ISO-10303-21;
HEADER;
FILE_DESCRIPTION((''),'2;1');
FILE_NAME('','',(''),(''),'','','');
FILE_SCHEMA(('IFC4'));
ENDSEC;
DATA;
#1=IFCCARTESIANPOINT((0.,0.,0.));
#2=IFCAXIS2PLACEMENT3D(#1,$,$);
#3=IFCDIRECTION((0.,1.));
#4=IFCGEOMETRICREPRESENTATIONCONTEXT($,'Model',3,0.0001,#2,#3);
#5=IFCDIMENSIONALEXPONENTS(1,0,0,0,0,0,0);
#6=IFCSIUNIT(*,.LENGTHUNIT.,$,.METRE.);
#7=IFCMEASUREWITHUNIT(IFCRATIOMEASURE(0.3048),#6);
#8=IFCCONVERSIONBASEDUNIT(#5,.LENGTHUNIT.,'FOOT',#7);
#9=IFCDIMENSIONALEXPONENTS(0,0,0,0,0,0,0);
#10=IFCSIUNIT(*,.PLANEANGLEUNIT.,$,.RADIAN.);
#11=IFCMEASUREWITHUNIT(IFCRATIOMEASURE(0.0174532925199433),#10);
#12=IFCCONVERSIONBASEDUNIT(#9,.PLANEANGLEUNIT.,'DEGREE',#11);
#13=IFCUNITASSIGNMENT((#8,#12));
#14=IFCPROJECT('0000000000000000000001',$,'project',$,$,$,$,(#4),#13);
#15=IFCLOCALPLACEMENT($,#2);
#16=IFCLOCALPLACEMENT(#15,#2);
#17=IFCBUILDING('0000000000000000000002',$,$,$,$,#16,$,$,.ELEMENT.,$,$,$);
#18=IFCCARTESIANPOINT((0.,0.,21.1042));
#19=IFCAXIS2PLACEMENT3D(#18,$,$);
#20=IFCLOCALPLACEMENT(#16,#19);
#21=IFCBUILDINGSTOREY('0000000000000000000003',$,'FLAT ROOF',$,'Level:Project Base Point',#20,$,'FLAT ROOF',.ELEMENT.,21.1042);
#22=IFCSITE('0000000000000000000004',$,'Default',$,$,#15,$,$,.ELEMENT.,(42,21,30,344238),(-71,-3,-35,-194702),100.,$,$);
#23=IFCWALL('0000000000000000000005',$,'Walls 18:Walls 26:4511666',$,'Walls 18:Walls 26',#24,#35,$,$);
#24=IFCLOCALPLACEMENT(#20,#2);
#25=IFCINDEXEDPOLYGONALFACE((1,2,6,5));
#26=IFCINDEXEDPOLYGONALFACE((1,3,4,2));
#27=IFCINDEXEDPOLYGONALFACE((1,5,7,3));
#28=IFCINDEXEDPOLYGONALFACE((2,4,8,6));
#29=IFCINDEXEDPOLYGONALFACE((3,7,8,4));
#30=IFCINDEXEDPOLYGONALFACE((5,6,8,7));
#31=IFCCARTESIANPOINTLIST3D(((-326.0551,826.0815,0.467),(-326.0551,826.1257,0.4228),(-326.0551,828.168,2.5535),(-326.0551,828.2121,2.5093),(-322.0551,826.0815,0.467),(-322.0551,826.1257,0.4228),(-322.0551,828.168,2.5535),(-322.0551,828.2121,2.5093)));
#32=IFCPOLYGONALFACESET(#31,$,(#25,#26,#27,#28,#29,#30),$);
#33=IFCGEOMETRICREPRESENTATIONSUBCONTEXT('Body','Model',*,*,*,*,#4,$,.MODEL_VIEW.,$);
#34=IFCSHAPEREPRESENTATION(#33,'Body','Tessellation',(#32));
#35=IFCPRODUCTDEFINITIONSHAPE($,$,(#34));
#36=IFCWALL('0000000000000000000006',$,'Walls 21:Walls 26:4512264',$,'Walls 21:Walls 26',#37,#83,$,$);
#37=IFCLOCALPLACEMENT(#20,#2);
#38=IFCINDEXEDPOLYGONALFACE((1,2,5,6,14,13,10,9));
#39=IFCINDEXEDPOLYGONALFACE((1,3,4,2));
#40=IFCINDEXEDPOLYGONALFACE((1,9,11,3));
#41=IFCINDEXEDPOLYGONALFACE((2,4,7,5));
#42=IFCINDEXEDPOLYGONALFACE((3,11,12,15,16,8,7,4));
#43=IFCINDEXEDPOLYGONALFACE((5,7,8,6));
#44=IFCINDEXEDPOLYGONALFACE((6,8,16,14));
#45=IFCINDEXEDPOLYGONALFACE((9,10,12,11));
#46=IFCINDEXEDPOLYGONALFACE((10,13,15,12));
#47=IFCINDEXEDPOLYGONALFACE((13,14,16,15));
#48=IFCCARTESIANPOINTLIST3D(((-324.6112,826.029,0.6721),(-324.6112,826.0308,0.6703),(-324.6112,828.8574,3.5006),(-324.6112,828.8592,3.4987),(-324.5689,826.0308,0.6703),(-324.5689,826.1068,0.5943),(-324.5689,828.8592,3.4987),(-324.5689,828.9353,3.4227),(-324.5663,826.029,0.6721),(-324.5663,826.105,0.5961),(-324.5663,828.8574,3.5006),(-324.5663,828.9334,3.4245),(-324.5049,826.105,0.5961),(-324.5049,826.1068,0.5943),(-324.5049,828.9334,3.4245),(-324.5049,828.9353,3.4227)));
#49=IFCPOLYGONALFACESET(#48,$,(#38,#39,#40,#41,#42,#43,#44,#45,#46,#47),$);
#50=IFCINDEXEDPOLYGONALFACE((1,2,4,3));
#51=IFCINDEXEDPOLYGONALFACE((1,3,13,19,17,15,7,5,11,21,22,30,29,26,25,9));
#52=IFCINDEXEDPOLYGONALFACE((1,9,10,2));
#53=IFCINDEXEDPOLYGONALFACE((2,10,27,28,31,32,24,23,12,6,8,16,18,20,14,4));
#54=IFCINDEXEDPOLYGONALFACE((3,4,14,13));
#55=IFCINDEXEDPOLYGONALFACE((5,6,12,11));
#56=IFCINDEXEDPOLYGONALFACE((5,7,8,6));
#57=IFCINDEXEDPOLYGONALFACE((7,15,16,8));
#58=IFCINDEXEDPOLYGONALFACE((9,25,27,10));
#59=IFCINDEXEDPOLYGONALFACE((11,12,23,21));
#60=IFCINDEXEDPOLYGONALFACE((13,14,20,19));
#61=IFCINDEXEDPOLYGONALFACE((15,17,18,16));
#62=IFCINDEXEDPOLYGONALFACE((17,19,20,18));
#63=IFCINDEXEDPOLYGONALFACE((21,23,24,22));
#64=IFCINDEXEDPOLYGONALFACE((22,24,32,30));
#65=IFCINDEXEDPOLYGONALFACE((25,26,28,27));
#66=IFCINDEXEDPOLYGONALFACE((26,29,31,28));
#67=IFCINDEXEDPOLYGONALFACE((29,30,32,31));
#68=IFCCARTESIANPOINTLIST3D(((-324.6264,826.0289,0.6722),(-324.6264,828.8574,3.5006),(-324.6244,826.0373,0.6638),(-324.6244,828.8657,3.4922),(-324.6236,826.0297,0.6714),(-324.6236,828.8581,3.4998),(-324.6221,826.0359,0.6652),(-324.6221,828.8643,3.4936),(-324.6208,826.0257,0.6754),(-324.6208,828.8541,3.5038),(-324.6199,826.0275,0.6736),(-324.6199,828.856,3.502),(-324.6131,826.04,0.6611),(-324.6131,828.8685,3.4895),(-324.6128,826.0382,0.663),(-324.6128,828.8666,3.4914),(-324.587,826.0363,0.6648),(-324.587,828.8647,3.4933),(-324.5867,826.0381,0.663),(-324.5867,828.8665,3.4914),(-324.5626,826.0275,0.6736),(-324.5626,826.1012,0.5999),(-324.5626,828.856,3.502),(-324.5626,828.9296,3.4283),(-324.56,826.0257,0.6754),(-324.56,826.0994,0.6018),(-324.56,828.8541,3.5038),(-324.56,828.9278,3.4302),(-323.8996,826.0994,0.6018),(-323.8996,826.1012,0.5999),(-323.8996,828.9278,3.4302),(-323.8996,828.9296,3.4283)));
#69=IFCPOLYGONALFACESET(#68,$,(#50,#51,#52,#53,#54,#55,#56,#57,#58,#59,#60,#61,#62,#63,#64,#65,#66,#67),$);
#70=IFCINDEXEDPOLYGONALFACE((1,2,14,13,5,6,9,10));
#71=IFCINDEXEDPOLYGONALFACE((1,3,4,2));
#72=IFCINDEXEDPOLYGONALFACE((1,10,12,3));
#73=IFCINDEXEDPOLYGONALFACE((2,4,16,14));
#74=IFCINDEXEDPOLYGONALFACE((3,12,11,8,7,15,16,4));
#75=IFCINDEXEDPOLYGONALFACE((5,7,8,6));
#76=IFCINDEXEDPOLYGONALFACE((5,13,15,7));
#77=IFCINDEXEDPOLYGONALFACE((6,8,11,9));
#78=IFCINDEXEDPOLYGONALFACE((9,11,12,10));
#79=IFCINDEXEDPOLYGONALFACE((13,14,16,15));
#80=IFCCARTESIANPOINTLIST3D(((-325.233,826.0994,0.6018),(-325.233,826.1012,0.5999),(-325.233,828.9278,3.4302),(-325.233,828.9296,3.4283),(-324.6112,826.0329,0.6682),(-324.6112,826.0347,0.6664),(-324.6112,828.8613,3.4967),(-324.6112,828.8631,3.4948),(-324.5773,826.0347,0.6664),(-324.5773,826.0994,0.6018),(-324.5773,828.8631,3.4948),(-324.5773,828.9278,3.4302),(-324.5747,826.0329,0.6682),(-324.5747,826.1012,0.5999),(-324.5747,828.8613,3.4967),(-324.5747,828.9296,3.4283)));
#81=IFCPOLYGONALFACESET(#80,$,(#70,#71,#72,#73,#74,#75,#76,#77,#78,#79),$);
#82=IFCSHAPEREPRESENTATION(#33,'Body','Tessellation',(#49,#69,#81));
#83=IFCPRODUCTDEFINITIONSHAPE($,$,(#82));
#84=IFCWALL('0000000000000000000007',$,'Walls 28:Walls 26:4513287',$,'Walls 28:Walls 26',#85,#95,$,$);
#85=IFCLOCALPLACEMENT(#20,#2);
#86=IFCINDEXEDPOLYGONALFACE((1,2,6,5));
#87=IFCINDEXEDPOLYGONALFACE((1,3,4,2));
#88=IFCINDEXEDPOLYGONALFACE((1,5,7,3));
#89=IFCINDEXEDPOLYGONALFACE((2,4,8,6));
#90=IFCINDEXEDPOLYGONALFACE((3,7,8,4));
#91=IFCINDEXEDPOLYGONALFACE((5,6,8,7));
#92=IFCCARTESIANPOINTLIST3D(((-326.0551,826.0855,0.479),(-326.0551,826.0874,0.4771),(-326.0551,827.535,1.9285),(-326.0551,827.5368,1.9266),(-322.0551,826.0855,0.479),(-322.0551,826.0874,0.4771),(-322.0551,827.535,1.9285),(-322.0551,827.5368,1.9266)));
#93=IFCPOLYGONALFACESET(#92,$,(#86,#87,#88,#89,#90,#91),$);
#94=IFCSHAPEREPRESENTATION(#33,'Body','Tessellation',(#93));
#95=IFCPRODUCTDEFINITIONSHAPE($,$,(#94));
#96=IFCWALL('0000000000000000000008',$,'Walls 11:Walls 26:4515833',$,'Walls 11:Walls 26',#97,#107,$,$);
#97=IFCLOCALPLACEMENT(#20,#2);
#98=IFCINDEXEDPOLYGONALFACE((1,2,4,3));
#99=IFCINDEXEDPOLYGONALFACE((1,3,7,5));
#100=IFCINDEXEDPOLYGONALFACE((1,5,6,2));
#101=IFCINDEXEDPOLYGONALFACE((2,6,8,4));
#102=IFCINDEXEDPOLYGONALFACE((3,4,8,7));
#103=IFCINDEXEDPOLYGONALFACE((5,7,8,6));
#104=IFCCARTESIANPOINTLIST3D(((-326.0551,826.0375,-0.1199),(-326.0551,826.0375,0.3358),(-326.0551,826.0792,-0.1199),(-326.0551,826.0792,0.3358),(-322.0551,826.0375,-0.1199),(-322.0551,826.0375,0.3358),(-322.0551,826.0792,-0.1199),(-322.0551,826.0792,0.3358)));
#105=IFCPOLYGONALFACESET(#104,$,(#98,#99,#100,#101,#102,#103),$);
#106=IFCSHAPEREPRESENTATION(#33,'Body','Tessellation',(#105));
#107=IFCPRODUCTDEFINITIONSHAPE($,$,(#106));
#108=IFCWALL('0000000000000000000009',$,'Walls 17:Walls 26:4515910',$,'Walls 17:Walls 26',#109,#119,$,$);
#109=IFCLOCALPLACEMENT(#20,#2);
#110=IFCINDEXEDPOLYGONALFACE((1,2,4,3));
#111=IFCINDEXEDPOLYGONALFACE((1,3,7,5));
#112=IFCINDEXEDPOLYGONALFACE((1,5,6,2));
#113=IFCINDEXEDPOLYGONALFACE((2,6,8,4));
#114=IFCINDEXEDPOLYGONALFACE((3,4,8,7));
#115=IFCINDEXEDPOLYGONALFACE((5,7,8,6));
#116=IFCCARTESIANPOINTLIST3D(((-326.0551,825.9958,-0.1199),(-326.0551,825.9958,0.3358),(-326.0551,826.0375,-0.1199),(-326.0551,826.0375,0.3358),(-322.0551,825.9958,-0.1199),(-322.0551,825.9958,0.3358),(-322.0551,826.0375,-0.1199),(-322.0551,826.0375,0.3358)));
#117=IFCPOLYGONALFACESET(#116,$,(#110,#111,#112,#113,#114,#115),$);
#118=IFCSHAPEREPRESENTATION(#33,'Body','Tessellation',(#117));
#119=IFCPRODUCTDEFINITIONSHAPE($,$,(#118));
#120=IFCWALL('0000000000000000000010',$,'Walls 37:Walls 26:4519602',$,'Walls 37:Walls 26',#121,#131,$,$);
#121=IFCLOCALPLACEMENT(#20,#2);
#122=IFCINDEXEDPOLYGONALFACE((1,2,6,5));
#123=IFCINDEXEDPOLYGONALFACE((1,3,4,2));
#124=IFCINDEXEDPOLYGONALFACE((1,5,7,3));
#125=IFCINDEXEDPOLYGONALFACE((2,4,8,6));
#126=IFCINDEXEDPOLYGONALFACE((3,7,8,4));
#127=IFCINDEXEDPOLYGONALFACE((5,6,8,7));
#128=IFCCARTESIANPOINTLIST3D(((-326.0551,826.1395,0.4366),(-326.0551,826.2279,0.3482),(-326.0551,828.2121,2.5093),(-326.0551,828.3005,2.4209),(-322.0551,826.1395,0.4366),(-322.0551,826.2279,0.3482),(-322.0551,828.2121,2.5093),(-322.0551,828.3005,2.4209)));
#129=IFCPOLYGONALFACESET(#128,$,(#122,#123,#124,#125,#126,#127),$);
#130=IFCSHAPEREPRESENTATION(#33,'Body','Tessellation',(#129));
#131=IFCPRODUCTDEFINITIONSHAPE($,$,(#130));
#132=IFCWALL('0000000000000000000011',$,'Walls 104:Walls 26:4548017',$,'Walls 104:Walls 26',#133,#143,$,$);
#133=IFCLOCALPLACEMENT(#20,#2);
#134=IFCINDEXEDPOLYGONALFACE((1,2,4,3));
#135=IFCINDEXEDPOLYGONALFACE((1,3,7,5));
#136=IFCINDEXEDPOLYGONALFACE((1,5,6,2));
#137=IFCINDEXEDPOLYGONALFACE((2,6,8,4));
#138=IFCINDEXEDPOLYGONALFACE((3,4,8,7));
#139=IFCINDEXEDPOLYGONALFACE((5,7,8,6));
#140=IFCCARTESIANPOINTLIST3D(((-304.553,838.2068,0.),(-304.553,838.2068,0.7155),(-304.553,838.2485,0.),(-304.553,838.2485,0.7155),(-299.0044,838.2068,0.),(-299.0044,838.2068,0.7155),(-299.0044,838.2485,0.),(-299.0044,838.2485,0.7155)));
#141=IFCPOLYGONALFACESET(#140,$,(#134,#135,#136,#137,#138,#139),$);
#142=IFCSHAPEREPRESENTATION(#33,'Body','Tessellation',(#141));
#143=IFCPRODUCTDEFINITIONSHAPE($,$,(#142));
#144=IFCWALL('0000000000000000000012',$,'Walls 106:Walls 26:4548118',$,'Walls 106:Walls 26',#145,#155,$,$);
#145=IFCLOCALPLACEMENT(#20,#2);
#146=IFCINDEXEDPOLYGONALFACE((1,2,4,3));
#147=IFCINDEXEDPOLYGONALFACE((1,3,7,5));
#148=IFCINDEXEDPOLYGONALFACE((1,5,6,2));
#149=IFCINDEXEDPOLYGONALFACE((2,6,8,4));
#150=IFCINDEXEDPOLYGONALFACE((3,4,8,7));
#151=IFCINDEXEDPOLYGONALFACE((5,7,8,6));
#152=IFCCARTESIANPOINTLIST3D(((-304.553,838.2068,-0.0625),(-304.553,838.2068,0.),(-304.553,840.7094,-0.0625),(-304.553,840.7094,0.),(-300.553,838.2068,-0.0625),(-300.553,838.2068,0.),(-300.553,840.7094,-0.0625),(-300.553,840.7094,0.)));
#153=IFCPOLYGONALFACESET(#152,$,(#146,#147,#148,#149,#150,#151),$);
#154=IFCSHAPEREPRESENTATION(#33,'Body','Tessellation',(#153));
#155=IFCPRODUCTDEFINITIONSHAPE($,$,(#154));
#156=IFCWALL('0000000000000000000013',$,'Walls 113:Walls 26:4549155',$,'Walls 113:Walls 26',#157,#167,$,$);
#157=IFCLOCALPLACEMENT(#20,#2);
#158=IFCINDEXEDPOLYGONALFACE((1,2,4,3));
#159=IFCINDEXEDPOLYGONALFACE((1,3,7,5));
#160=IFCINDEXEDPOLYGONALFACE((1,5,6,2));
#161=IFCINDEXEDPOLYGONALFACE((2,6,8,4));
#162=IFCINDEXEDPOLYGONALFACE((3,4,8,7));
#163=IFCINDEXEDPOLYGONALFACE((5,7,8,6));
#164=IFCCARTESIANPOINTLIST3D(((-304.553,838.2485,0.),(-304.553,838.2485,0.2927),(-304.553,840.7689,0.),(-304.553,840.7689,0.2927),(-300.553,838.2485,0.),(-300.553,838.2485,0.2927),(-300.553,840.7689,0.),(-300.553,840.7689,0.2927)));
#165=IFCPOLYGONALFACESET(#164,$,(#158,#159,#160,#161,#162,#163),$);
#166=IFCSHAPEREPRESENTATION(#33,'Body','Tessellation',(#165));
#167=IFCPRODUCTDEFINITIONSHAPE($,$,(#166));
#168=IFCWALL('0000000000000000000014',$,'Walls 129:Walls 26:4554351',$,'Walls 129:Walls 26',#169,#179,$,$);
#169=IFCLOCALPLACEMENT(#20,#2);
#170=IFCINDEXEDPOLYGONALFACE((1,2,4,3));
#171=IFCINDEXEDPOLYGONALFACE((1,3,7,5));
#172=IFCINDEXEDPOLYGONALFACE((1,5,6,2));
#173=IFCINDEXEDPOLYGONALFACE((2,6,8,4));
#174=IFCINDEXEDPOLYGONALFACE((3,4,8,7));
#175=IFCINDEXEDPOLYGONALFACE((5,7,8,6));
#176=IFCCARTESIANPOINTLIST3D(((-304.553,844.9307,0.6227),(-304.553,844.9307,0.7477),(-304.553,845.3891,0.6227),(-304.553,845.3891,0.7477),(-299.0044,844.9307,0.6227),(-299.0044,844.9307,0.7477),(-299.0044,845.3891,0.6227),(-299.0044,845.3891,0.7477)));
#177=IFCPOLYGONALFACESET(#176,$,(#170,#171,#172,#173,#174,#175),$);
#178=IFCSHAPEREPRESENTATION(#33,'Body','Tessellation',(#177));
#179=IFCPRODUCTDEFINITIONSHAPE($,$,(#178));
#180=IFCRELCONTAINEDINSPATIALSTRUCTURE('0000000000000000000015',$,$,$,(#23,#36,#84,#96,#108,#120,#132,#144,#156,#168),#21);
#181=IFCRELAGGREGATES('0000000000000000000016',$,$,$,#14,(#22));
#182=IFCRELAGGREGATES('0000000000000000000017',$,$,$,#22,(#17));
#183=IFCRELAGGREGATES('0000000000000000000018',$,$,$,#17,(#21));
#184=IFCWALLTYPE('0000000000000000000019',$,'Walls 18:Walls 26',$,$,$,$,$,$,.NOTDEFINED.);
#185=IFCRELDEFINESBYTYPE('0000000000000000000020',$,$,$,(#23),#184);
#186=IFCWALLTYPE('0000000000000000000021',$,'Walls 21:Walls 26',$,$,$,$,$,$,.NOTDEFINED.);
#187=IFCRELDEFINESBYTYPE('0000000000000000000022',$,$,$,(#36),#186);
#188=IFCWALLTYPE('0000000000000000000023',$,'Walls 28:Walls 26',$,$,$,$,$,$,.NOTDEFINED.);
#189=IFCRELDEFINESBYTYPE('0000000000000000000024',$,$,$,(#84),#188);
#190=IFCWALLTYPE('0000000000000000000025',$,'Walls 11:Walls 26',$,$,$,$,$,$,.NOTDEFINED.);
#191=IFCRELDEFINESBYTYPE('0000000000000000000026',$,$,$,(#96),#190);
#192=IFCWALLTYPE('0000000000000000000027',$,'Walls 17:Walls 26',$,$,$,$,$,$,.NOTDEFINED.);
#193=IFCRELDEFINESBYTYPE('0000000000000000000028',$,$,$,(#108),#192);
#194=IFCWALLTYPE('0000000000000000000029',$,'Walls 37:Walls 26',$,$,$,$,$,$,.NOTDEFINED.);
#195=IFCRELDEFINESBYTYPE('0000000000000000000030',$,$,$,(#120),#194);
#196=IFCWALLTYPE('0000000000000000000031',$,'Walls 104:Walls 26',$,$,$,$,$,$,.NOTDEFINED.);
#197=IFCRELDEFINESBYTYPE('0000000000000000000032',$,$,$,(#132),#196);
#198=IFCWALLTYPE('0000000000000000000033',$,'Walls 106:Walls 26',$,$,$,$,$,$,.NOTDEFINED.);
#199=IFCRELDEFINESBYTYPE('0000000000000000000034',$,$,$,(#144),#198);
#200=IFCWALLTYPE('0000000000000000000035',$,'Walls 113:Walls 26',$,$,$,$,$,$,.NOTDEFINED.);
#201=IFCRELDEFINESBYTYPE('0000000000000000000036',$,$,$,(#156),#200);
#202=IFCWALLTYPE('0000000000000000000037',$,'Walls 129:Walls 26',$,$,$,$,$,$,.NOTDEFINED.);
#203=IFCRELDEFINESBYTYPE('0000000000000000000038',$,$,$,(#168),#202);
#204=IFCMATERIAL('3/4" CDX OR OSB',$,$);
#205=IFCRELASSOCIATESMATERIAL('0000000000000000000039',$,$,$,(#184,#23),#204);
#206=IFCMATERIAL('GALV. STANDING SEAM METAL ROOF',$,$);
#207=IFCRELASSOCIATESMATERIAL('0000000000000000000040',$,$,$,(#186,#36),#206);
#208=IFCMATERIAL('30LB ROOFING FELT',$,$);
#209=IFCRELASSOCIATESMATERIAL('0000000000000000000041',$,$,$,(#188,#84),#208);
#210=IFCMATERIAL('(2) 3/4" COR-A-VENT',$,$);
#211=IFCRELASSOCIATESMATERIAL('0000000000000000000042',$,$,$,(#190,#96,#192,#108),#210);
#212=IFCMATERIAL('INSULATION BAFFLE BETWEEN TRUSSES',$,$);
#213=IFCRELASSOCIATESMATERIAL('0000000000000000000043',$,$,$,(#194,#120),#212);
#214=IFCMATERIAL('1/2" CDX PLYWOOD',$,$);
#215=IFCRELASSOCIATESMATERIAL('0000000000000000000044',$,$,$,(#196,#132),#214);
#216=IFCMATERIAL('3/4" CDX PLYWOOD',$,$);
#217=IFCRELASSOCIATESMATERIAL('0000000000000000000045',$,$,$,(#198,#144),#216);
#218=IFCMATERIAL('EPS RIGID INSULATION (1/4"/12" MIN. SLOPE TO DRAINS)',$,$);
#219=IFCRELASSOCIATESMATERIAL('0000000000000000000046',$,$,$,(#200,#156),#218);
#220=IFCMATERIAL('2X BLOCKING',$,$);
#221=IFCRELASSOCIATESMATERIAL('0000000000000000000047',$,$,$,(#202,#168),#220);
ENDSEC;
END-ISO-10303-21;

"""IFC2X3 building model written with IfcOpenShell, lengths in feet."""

from ifc_helpers import new_model, entity, si_unit, converted_unit, direction, frame, frame_2d, origin, origin_2d_with_axis, place, context, subcontext, project, spatial, polyline, rectangle, outline, extrude, material, type_object, element, save


model = new_model("IFC2X3")

# Units and contexts
model_context = context("Model", 3, precision=0.0001, world=origin(), true_north=direction((0.0, 1.0)))
body_context = subcontext(model_context, "Body", "Model", "MODEL_VIEW")
ifc_project = project(units=[converted_unit("LENGTHUNIT", "FOOT", entity("IfcRatioMeasure", 0.3048), si_unit("LENGTHUNIT", "METRE"), dimensions=[1, 0, 0, 0, 0, 0, 0]), converted_unit("PLANEANGLEUNIT", "DEGREE", entity("IfcRatioMeasure", 0.0174532925199433), si_unit("PLANEANGLEUNIT", "RADIAN"), dimensions=[0, 0, 0, 0, 0, 0, 0])], contexts=[model_context])

# Site, building, storey
site_placement = place(None, origin())
site = spatial("IfcSite", under=ifc_project, at=site_placement, Name="Default", CompositionType="ELEMENT", RefLatitude=(42, 21, 30, 344238), RefLongitude=(-71, -3, -35, -194702), RefElevation=100.0)
building_placement = place(site_placement, origin())
building = spatial("IfcBuilding", under=site, at=building_placement, CompositionType="ELEMENT")
storey_placement = place(building_placement, frame((0.0, 0.0, 21.1042)))
storey = spatial("IfcBuildingStorey", under=building, at=storey_placement, Name="FLAT ROOF", ObjectType="Level:Project Base Point", LongName="FLAT ROOF", CompositionType="ELEMENT", Elevation=21.1042)

# Walls
ifc_material_1 = material(Name="3/4\" CDX OR OSB")
wall_type_1 = type_object("IfcWallType", Name="Walls 18:Walls 26", PredefinedType="NOTDEFINED", material=ifc_material_1)
wall_1_placement = place(storey_placement, frame((-326.0551, 826.0815, 0.4228)))
element("IfcWall", 1, at=wall_1_placement, inside=storey, type_object=wall_type_1, material=ifc_material_1, Name="Walls 18:Walls 26:4511666", ObjectType="Walls 18:Walls 26", context=body_context, shape_type="SweptSolid", body=[
    extrude(rectangle(XDim=0.0625, YDim=4.0, at=frame_2d((0.0, 0.0), x_axis=(0.0, 1.0))), frame((2.0, 0.0221, 0.0221), z_axis=(0.0, 0.707107, 0.707107), x_axis=(-1.0, 0.0, 0.0)), (0.0, 0.0, 1.0), 2.9507),
])
ifc_material_2 = material(Name="GALV. STANDING SEAM METAL ROOF")
wall_type_2 = type_object("IfcWallType", Name="Walls 21:Walls 26", PredefinedType="NOTDEFINED", material=ifc_material_2)
wall_2_placement = place(storey_placement, frame((-325.233, 826.0257, 0.5943), z_axis=(0.0, 0.0, 1.0), x_axis=(0.0, 1.0, 0.0)))
element("IfcWall", 2, at=wall_2_placement, inside=storey, type_object=wall_type_2, material=ifc_material_2, Name="Walls 21:Walls 26:4512264", ObjectType="Walls 21:Walls 26", context=body_context, shape_type="SweptSolid", body=[
    extrude(outline(polyline([(-0.0551, 0.0061), (-0.0551, -0.0579), (-0.0525, -0.0579), (-0.0525, 0.0035), (0.0551, 0.0035), (0.0551, 0.0484), (0.0525, 0.0484), (0.0525, 0.0061), (-0.0551, 0.0061)])), frame((0.0422, -0.6702, 0.0389), z_axis=(-0.707107, 0.0, -0.707107), x_axis=(-0.707107, 0.0, 0.707107)), (0.0, 0.0, -1.0), 4.0),
    extrude(outline(polyline([(-0.0471, -0.1057), (-0.0495, -0.1015), (-0.0395, -0.0451), (0.0631, -0.0632), (0.1784, 0.5896), (0.1759, 0.5901), (0.061, -0.0602), (-0.0416, -0.0421), (-0.0522, -0.102), (-0.0487, -0.1083), (-0.0367, -0.1083), (-0.0309, -0.0979), (-0.029, -0.0715), (-0.0316, -0.0713), (-0.0334, -0.0971), (-0.0382, -0.1057), (-0.0471, -0.1057)])), frame((0.0238, -0.7217, 0.0573), z_axis=(-0.707107, 0.0, -0.707107), x_axis=(0.696318, -0.174018, -0.696318)), (0.0, 0.0, -1.0), 4.0),
    extrude(outline(polyline([(-0.1743, -0.0483), (0.4839, -0.0483), (0.4839, -0.0457), (-0.1717, -0.0457), (-0.1717, 0.0457), (-0.1379, 0.0457), (-0.1379, 0.0483), (-0.1743, 0.0483), (-0.1743, -0.0483)])), frame((0.0413, -0.4839, 0.0398), z_axis=(0.707107, 0.0, 0.707107), x_axis=(0.0, 1.0, 0.0)), (0.0, 0.0, 1.0), 4.0),
])
ifc_material_3 = material(Name="30LB ROOFING FELT")
wall_type_3 = type_object("IfcWallType", Name="Walls 28:Walls 26", PredefinedType="NOTDEFINED", material=ifc_material_3)
wall_3_placement = place(storey_placement, frame((-326.0551, 826.0855, 0.4771)))
element("IfcWall", 3, at=wall_3_placement, inside=storey, type_object=wall_type_3, material=ifc_material_3, Name="Walls 28:Walls 26:4513287", ObjectType="Walls 28:Walls 26", context=body_context, shape_type="SweptSolid", body=[
    extrude(rectangle(XDim=2.0499, YDim=4.0, at=frame_2d((0.0, 0.0), x_axis=(0.0, 1.0))), frame((2.0, 0.7266, 0.7247), z_axis=(0.0, -0.707107, 0.707107), x_axis=(-1.0, 0.0, 0.0)), (0.0, 0.0, 1.0), 0.0026),
])
ifc_material_4 = material(Name="(2) 3/4\" COR-A-VENT")
wall_type_4 = type_object("IfcWallType", Name="Walls 11:Walls 26", PredefinedType="NOTDEFINED", material=ifc_material_4)
wall_4_placement = place(storey_placement, frame((-326.0551, 826.0375, -0.1199)))
element("IfcWall", 4, at=wall_4_placement, inside=storey, type_object=wall_type_4, material=ifc_material_4, Name="Walls 11:Walls 26:4515833", ObjectType="Walls 11:Walls 26", context=body_context, shape_type="SweptSolid", body=[
    extrude(rectangle(XDim=4.0, YDim=0.0417, at=frame_2d((0.0, 0.0), x_axis=(1.0, 0.0))), frame((2.0, 0.0208, 0.0), z_axis=(0.0, 0.0, 1.0), x_axis=(-1.0, 0.0, 0.0)), (0.0, 0.0, 1.0), 0.4557),
])
wall_type_5 = type_object("IfcWallType", Name="Walls 17:Walls 26", PredefinedType="NOTDEFINED", material=ifc_material_4)
wall_5_placement = place(storey_placement, frame((-326.0551, 825.9958, -0.1199)))
element("IfcWall", 5, at=wall_5_placement, inside=storey, type_object=wall_type_5, material=ifc_material_4, Name="Walls 17:Walls 26:4515910", ObjectType="Walls 17:Walls 26", context=body_context, shape_type="SweptSolid", body=[
    extrude(rectangle(XDim=4.0, YDim=0.0417, at=frame_2d((0.0, 0.0), x_axis=(1.0, 0.0))), frame((2.0, 0.0208, 0.0), z_axis=(0.0, 0.0, 1.0), x_axis=(-1.0, 0.0, 0.0)), (0.0, 0.0, 1.0), 0.4557),
])
ifc_material_5 = material(Name="INSULATION BAFFLE BETWEEN TRUSSES")
wall_type_6 = type_object("IfcWallType", Name="Walls 37:Walls 26", PredefinedType="NOTDEFINED", material=ifc_material_5)
wall_6_placement = place(storey_placement, frame((-326.0551, 826.1395, 0.3482)))
element("IfcWall", 6, at=wall_6_placement, inside=storey, type_object=wall_type_6, material=ifc_material_5, Name="Walls 37:Walls 26:4519602", ObjectType="Walls 37:Walls 26", context=body_context, shape_type="SweptSolid", body=[
    extrude(rectangle(XDim=0.125, YDim=4.0, at=frame_2d((0.0, 0.0), x_axis=(0.0, 1.0))), frame((2.0, 0.0442, 0.0442), z_axis=(0.0, 0.707107, 0.707107), x_axis=(-1.0, 0.0, 0.0)), (0.0, 0.0, 1.0), 2.9312),
])
ifc_material_6 = material(Name="1/2\" CDX PLYWOOD")
wall_type_7 = type_object("IfcWallType", Name="Walls 104:Walls 26", PredefinedType="NOTDEFINED", material=ifc_material_6)
wall_7_placement = place(storey_placement, frame((-304.553, 838.2068, 0.0)))
element("IfcWall", 7, at=wall_7_placement, inside=storey, type_object=wall_type_7, material=ifc_material_6, Name="Walls 104:Walls 26:4548017", ObjectType="Walls 104:Walls 26", context=body_context, shape_type="SweptSolid", body=[
    extrude(rectangle(XDim=5.5486, YDim=0.0417, at=frame_2d((0.0, 0.0), x_axis=(1.0, 0.0))), frame((2.7743, 0.0208, 0.0), z_axis=(0.0, 0.0, 1.0), x_axis=(-1.0, 0.0, 0.0)), (0.0, 0.0, 1.0), 0.7155),
])
ifc_material_7 = material(Name="3/4\" CDX PLYWOOD")
wall_type_8 = type_object("IfcWallType", Name="Walls 106:Walls 26", PredefinedType="NOTDEFINED", material=ifc_material_7)
wall_8_placement = place(storey_placement, frame((-304.553, 838.2068, -0.0625)))
element("IfcWall", 8, at=wall_8_placement, inside=storey, type_object=wall_type_8, material=ifc_material_7, Name="Walls 106:Walls 26:4548118", ObjectType="Walls 106:Walls 26", context=body_context, shape_type="SweptSolid", body=[
    extrude(rectangle(XDim=4.0, YDim=2.5026, at=origin_2d_with_axis()), frame((2.0, 1.2513, 0.0), z_axis=(0.0, 0.0, 1.0), x_axis=(-1.0, 0.0, 0.0)), (0.0, 0.0, 1.0), 0.0625),
])
ifc_material_8 = material(Name="EPS RIGID INSULATION (1/4\"/12\" MIN. SLOPE TO DRAINS)")
wall_type_9 = type_object("IfcWallType", Name="Walls 113:Walls 26", PredefinedType="NOTDEFINED", material=ifc_material_8)
wall_9_placement = place(storey_placement, frame((-304.553, 838.2485, 0.0)))
element("IfcWall", 9, at=wall_9_placement, inside=storey, type_object=wall_type_9, material=ifc_material_8, Name="Walls 113:Walls 26:4549155", ObjectType="Walls 113:Walls 26", context=body_context, shape_type="SweptSolid", body=[
    extrude(rectangle(XDim=4.0, YDim=2.5204, at=origin_2d_with_axis()), frame((2.0, 1.2602, 0.0), z_axis=(0.0, 0.0, 1.0), x_axis=(-1.0, 0.0, 0.0)), (0.0, 0.0, 1.0), 0.2927),
])
ifc_material_9 = material(Name="2X BLOCKING")
wall_type_10 = type_object("IfcWallType", Name="Walls 129:Walls 26", PredefinedType="NOTDEFINED", material=ifc_material_9)
wall_10_placement = place(storey_placement, frame((-304.553, 844.9307, 0.6227)))
element("IfcWall", 10, at=wall_10_placement, inside=storey, type_object=wall_type_10, material=ifc_material_9, Name="Walls 129:Walls 26:4554351", ObjectType="Walls 129:Walls 26", context=body_context, shape_type="SweptSolid", body=[
    extrude(rectangle(XDim=5.5486, YDim=0.4583, at=origin_2d_with_axis()), frame((2.7743, 0.2292, 0.0), z_axis=(0.0, 0.0, 1.0), x_axis=(-1.0, 0.0, 0.0)), (0.0, 0.0, 1.0), 0.125),
])

save(model, "model.ifc")
